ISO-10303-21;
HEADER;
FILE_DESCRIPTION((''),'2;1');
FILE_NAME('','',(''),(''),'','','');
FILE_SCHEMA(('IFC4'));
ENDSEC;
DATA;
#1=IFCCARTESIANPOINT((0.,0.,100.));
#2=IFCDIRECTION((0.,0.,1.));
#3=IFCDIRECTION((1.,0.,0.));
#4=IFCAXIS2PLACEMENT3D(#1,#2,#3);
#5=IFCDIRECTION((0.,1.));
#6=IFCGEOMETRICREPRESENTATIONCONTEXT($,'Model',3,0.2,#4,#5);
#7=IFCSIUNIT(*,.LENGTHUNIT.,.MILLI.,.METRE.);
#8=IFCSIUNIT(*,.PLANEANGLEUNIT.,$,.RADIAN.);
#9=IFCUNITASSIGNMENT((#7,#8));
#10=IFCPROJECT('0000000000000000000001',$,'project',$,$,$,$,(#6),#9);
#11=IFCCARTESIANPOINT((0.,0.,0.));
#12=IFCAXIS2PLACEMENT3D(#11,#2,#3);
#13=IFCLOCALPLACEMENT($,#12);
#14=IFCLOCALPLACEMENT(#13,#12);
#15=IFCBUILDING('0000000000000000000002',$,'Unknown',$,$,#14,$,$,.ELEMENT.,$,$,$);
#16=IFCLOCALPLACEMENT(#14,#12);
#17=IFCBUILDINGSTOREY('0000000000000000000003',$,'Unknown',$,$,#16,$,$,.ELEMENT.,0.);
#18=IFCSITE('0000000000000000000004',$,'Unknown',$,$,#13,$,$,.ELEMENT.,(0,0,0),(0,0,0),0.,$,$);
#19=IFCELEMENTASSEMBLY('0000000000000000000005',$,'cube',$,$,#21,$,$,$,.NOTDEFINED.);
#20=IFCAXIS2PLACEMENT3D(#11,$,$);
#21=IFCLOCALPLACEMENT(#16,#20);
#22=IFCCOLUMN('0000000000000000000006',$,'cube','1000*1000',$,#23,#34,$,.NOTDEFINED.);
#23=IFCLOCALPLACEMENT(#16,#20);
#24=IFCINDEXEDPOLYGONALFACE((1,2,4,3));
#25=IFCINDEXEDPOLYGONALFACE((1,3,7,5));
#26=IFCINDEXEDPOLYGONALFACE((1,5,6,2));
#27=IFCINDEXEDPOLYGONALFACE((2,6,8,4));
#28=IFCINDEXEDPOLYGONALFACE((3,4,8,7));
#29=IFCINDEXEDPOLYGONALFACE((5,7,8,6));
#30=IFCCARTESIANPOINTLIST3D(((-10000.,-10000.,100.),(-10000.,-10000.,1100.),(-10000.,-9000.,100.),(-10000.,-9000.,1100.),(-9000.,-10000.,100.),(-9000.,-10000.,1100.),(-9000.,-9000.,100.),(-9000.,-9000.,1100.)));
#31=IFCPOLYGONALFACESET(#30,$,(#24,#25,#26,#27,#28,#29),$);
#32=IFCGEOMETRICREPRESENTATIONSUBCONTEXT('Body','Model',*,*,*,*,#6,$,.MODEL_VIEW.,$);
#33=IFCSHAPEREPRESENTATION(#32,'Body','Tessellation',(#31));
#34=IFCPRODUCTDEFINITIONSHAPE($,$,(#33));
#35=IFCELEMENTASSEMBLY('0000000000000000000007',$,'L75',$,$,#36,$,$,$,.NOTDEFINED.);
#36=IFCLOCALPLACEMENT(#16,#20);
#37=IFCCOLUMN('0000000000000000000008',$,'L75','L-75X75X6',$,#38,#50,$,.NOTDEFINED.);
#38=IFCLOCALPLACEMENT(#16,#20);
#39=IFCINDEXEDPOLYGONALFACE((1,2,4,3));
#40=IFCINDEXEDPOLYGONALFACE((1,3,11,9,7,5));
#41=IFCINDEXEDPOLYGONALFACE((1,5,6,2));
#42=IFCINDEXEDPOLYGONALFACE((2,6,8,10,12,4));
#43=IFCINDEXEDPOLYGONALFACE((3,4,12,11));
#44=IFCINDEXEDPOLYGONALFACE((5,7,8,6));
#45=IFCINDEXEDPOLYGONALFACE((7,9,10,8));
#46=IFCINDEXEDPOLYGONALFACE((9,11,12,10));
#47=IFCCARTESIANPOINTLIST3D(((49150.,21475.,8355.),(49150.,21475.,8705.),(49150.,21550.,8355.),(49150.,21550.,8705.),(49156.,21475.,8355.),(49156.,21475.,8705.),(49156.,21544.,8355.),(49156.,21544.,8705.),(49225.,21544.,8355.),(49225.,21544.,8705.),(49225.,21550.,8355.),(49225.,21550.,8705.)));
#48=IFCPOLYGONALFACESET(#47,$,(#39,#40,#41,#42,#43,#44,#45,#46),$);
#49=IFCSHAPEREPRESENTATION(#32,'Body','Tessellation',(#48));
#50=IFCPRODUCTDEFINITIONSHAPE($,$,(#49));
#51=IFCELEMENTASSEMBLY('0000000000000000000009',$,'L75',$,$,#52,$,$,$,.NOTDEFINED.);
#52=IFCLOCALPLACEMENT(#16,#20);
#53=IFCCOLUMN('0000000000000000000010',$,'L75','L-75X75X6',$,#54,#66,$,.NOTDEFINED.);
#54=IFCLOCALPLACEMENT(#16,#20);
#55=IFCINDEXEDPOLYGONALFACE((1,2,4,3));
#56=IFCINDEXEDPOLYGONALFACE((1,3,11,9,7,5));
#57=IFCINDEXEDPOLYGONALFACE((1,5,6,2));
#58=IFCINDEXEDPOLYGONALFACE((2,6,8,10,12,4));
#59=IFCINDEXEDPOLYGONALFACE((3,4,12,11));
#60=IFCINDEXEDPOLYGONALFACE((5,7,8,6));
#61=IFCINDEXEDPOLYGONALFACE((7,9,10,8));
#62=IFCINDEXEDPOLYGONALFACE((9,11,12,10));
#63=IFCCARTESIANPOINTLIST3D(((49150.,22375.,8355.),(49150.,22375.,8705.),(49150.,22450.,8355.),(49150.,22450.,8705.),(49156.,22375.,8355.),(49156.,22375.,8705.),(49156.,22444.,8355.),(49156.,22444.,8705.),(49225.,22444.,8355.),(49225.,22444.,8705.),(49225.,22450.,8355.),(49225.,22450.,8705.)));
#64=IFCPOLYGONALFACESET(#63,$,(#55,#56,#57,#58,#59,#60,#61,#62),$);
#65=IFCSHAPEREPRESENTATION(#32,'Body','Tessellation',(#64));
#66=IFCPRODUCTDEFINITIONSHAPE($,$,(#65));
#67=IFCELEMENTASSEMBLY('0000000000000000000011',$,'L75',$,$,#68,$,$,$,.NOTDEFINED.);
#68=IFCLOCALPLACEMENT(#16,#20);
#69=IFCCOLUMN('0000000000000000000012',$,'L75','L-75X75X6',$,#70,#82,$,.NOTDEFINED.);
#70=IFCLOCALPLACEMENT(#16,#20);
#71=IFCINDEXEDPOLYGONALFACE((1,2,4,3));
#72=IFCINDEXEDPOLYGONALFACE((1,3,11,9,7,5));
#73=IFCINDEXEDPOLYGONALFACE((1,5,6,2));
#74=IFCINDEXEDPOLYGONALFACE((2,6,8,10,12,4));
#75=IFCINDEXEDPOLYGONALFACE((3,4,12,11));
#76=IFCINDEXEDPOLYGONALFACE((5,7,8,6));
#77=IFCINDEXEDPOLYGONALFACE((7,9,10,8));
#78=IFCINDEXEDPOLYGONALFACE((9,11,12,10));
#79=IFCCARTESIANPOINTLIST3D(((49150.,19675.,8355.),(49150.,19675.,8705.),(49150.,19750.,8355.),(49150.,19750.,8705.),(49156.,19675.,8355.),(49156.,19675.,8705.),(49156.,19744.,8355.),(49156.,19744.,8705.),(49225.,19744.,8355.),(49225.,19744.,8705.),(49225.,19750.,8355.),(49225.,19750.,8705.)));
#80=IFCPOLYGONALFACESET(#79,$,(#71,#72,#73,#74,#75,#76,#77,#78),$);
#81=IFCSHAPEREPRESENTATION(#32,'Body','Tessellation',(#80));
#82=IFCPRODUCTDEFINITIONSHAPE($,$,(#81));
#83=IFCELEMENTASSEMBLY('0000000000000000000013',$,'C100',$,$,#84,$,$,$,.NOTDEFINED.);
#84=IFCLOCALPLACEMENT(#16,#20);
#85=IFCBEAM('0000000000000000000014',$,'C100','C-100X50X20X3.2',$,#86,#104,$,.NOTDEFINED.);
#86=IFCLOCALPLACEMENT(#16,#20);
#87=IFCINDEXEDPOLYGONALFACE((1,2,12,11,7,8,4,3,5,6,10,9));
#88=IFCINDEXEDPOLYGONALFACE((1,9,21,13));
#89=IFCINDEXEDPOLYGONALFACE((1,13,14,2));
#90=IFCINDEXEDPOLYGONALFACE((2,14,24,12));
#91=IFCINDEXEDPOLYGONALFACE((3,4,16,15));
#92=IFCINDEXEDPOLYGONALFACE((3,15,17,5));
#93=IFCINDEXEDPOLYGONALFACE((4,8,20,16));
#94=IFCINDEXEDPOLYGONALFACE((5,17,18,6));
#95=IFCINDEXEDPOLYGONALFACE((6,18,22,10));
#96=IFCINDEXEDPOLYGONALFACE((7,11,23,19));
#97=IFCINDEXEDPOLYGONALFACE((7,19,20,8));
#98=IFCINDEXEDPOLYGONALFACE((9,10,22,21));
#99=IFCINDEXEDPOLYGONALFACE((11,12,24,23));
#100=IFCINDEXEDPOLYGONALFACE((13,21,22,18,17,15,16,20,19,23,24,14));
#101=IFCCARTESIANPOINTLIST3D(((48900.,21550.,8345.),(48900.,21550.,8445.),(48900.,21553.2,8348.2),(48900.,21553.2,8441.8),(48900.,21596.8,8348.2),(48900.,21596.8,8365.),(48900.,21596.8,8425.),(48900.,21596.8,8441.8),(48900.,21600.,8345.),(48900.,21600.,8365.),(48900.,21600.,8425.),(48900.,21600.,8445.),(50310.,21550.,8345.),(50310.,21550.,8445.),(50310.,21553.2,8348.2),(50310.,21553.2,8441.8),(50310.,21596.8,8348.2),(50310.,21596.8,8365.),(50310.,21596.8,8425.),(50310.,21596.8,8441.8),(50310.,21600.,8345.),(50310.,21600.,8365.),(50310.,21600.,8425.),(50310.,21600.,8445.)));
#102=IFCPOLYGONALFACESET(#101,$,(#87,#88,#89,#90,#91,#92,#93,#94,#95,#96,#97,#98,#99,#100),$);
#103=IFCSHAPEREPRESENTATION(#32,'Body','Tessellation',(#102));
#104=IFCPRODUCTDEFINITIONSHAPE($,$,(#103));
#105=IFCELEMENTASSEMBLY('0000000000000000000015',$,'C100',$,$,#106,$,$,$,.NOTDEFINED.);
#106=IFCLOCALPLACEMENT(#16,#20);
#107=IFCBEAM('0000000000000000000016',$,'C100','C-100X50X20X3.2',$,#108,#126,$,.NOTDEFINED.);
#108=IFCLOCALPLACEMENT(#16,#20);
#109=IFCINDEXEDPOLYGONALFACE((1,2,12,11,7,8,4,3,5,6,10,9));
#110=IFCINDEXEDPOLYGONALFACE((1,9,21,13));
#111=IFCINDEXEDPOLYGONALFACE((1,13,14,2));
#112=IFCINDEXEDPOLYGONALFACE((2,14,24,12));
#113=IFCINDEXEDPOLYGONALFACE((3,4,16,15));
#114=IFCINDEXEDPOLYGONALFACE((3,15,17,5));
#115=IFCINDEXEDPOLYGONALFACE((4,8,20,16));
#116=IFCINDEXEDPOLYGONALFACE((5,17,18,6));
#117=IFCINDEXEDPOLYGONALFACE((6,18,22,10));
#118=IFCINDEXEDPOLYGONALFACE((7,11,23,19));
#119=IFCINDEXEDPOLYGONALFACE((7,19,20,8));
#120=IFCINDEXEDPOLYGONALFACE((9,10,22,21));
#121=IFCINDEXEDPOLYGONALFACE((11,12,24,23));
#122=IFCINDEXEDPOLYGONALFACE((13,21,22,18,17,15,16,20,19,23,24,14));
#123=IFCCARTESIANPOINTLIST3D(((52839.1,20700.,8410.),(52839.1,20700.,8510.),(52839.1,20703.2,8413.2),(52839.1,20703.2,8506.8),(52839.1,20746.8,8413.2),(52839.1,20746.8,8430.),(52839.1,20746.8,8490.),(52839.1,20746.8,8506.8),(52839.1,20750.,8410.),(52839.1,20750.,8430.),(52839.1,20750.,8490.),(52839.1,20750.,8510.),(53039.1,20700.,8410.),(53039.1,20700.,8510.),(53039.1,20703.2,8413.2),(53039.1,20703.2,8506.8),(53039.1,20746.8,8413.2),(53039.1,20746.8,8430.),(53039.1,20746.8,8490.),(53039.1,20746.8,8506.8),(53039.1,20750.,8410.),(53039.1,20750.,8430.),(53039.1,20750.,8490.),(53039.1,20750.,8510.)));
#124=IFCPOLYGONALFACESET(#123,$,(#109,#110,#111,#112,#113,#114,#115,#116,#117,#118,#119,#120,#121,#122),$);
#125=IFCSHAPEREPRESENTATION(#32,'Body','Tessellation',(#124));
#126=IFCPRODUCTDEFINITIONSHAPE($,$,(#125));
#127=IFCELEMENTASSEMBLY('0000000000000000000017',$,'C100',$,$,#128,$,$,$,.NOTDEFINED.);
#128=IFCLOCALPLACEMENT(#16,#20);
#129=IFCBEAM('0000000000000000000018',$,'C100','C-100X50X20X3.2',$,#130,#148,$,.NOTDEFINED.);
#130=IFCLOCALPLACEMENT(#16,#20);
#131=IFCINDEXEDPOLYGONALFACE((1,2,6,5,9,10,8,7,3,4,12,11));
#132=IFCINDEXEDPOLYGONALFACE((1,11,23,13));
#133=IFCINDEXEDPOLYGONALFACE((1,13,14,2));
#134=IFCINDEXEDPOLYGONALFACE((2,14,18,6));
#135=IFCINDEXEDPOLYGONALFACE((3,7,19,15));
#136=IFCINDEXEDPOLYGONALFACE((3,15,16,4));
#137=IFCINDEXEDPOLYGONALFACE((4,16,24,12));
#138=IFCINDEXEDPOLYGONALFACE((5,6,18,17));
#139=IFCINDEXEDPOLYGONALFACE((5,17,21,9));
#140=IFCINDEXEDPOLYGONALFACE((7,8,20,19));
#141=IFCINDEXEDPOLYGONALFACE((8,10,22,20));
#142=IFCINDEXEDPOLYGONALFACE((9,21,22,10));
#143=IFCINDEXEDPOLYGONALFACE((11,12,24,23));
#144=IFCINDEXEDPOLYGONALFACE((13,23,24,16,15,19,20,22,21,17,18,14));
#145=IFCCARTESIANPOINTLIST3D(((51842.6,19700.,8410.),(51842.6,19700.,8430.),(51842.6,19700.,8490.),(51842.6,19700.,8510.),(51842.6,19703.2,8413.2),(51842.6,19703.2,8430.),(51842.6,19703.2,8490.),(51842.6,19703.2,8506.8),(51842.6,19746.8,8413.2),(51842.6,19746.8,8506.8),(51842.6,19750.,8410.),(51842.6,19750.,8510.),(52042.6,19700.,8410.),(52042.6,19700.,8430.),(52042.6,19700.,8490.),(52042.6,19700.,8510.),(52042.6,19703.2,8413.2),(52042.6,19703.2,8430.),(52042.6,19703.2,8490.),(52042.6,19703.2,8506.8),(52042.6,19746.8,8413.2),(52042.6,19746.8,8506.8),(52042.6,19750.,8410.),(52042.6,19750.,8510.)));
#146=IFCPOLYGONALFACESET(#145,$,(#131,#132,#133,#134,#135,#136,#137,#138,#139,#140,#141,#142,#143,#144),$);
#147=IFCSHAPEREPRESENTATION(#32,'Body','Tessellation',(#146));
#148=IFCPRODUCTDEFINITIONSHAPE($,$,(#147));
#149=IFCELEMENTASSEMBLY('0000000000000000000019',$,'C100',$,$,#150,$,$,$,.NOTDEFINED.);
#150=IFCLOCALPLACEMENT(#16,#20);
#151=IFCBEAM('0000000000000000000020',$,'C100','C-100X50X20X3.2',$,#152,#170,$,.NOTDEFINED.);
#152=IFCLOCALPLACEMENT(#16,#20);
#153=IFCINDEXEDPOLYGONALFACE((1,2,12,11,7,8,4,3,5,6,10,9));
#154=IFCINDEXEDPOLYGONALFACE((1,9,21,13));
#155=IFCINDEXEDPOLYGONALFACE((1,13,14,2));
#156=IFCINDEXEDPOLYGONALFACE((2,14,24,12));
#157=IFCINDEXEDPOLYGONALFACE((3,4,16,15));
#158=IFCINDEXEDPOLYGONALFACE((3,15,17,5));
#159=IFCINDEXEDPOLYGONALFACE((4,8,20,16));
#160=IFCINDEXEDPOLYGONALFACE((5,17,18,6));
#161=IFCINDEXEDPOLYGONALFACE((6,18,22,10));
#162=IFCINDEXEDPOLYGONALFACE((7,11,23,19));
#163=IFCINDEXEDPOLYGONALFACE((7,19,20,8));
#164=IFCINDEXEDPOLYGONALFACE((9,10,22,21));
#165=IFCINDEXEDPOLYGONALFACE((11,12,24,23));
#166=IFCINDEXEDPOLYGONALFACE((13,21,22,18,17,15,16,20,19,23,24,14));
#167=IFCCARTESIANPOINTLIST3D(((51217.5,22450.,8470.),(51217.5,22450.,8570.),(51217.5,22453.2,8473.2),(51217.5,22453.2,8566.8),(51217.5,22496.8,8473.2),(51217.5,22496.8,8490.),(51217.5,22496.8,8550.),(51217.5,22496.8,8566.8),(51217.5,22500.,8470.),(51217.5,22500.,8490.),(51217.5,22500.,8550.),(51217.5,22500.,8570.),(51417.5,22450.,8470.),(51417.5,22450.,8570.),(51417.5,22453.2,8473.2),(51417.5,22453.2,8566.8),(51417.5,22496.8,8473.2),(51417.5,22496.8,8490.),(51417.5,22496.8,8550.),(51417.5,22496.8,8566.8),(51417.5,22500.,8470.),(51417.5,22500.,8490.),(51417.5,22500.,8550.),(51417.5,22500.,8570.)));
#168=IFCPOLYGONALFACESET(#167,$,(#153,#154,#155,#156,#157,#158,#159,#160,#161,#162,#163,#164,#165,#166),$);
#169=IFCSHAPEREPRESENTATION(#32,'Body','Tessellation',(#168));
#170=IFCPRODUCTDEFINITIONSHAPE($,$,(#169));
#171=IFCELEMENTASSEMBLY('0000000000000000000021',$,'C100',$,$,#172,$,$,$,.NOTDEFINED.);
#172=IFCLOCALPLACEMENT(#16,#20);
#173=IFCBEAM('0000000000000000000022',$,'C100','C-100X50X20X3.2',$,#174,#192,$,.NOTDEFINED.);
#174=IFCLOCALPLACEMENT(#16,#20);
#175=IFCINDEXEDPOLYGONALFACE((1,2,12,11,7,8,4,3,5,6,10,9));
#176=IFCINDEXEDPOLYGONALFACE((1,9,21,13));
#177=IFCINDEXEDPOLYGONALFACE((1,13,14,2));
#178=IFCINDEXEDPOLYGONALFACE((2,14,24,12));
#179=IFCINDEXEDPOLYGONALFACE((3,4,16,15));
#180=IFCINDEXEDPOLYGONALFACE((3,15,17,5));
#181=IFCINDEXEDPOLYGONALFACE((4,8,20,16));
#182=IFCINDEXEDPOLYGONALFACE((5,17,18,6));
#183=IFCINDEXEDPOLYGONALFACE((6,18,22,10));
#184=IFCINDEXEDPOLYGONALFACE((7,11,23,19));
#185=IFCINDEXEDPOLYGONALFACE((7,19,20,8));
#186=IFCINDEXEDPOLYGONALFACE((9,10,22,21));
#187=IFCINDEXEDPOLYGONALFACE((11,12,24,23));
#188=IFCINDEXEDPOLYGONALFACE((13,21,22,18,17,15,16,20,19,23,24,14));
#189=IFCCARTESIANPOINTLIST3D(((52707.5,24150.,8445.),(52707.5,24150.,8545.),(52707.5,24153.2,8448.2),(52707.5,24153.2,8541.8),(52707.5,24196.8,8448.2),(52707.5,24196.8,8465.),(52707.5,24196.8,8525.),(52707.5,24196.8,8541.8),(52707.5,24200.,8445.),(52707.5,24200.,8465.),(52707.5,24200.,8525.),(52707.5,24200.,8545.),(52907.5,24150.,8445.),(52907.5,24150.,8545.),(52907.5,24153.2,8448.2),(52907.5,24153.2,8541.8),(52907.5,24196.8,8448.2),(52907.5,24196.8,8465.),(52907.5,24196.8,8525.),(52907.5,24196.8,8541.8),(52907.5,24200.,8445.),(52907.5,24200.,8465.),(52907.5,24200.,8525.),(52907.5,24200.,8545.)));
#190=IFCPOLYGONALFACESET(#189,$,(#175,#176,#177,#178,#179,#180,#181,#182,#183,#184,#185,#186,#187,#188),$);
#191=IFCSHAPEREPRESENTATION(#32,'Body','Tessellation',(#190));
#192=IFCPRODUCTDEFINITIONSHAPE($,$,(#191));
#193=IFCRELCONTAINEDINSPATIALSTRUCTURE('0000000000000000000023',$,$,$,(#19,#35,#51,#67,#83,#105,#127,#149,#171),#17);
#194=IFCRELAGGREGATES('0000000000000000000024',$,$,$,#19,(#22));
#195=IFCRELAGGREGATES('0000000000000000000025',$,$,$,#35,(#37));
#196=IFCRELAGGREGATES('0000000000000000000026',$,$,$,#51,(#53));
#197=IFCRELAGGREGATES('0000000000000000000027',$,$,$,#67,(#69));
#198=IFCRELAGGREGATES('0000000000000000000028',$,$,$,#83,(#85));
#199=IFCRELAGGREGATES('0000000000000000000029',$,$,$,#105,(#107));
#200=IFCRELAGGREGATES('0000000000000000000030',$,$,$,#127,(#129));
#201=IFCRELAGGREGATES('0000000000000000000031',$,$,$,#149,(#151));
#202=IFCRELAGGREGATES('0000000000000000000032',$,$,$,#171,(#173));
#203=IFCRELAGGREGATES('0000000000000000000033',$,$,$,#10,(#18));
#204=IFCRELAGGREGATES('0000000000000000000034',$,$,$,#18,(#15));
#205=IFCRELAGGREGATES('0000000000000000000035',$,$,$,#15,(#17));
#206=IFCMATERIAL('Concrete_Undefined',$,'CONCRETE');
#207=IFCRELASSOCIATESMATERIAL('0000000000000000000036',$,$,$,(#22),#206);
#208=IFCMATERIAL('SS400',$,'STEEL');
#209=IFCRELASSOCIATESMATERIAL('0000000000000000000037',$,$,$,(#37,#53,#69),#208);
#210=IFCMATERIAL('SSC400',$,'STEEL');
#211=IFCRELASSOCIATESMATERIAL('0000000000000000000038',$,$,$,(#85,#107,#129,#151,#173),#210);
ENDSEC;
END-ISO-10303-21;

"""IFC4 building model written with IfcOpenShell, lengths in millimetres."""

from ifc_helpers import new_model, si_unit, direction, frame, origin_with_axes, place, context, subcontext, project, spatial, line, indexed_curve, outline, extrude, material, element, aggregate, save


model = new_model("IFC4")

# Units and contexts
model_context = context("Model", 3, precision=0.2, world=frame((0.0, 0.0, 100.0), z_axis=(0.0, 0.0, 1.0), x_axis=(1.0, 0.0, 0.0)), true_north=direction((0.0, 1.0)))
body_context = subcontext(model_context, "Body", "Model", "MODEL_VIEW")
ifc_project = project(units=[si_unit("LENGTHUNIT", "METRE", prefix="MILLI"), si_unit("PLANEANGLEUNIT", "RADIAN")], contexts=[model_context])

# Site, building, storey
site_placement = place(None, origin_with_axes())
site = spatial("IfcSite", under=ifc_project, at=site_placement, Name="Unknown", CompositionType="ELEMENT", RefLatitude=(0, 0, 0), RefLongitude=(0, 0, 0), RefElevation=0.0)
building_placement = place(site_placement, origin_with_axes())
building = spatial("IfcBuilding", under=site, at=building_placement, Name="Unknown", CompositionType="ELEMENT")
storey_placement = place(building_placement, origin_with_axes())
storey = spatial("IfcBuildingStorey", under=building, at=storey_placement, Name="Unknown", CompositionType="ELEMENT", Elevation=0.0)

# Element assemblies, columns
assembly_1_placement = place(storey_placement, frame((-9500.0, -9500.0, 100.0), z_axis=(-1.0, 0.0, 0.0), x_axis=(0.0, 0.0, 1.0)))
assembly_1 = element("IfcElementAssembly", 1, at=assembly_1_placement, inside=storey, Name="cube", PredefinedType="NOTDEFINED")
ifc_material_1 = material(Name="Concrete_Undefined", Category="CONCRETE")
column_1_placement = place(assembly_1_placement, origin_with_axes())
column_1 = element("IfcColumn", 2, at=column_1_placement, material=ifc_material_1, Name="cube", Description="1000*1000", PredefinedType="NOTDEFINED", context=body_context, shape_type="SolidModel", body=[
    extrude(outline(indexed_curve([(-500.0, -500.0), (500.0, -500.0), (500.0, 500.0), (-500.0, 500.0)], segments=[line(1, 2, 3, 4, 1)])), frame((0.0, 0.0, 0.0), z_axis=(-1.0, 0.0, 0.0), x_axis=(0.0, 0.0, 1.0)), (0.0, 0.0, -1.0), 1000.0),
])
aggregate(assembly_1, [column_1])
assembly_2_placement = place(storey_placement, frame((49187.5, 21512.5, 8355.0), z_axis=(1.0, 0.0, 0.0), x_axis=(0.0, 0.0, 1.0)))
assembly_2 = element("IfcElementAssembly", 3, at=assembly_2_placement, inside=storey, Name="L75", PredefinedType="NOTDEFINED")
ifc_material_2 = material(Name="SS400", Category="STEEL")
column_2_placement = place(assembly_2_placement, origin_with_axes())
column_2 = element("IfcColumn", 4, at=column_2_placement, material=ifc_material_2, Name="L75", Description="L-75X75X6", PredefinedType="NOTDEFINED", context=body_context, shape_type="SolidModel", body=[
    extrude(outline(indexed_curve([(-37.5, -37.5), (37.5, -37.5), (37.5, -31.5), (-31.5, -31.5), (-31.5, 37.5), (-37.5, 37.5)], segments=[line(1, 2, 3, 4, 5, 6, 1)])), frame((0.0, 0.0, 0.0), z_axis=(-1.0, 0.0, 0.0), x_axis=(0.0, 0.0, 1.0)), (0.0, 0.0, -1.0), 350.0),
])
aggregate(assembly_2, [column_2])
assembly_3_placement = place(storey_placement, frame((49187.5, 22412.5, 8355.0), z_axis=(1.0, 0.0, 0.0), x_axis=(0.0, 0.0, 1.0)))
assembly_3 = element("IfcElementAssembly", 5, at=assembly_3_placement, inside=storey, Name="L75", PredefinedType="NOTDEFINED")
column_3_placement = place(assembly_3_placement, origin_with_axes())
column_3 = element("IfcColumn", 6, at=column_3_placement, material=ifc_material_2, Name="L75", Description="L-75X75X6", PredefinedType="NOTDEFINED", context=body_context, shape_type="SolidModel", body=[
    extrude(outline(indexed_curve([(-37.5, -37.5), (37.5, -37.5), (37.5, -31.5), (-31.5, -31.5), (-31.5, 37.5), (-37.5, 37.5)], segments=[line(1, 2, 3, 4, 5, 6, 1)])), frame((0.0, 0.0, 0.0), z_axis=(-1.0, 0.0, 0.0), x_axis=(0.0, 0.0, 1.0)), (0.0, 0.0, -1.0), 350.0),
])
aggregate(assembly_3, [column_3])
assembly_4_placement = place(storey_placement, frame((49187.5, 19712.5, 8355.0), z_axis=(1.0, 0.0, 0.0), x_axis=(0.0, 0.0, 1.0)))
assembly_4 = element("IfcElementAssembly", 7, at=assembly_4_placement, inside=storey, Name="L75", PredefinedType="NOTDEFINED")
column_4_placement = place(assembly_4_placement, origin_with_axes())
column_4 = element("IfcColumn", 8, at=column_4_placement, material=ifc_material_2, Name="L75", Description="L-75X75X6", PredefinedType="NOTDEFINED", context=body_context, shape_type="SolidModel", body=[
    extrude(outline(indexed_curve([(-37.5, -37.5), (37.5, -37.5), (37.5, -31.5), (-31.5, -31.5), (-31.5, 37.5), (-37.5, 37.5)], segments=[line(1, 2, 3, 4, 5, 6, 1)])), frame((0.0, 0.0, 0.0), z_axis=(-1.0, 0.0, 0.0), x_axis=(0.0, 0.0, 1.0)), (0.0, 0.0, -1.0), 350.0),
])
aggregate(assembly_4, [column_4])

# Element assemblies, beams
assembly_5_placement = place(storey_placement, frame((48900.0, 21575.0, 8395.0), z_axis=(0.0, 1.0, 0.0), x_axis=(1.0, 0.0, 0.0)))
assembly_5 = element("IfcElementAssembly", 9, at=assembly_5_placement, inside=storey, Name="C100", PredefinedType="NOTDEFINED")
ifc_material_3 = material(Name="SSC400", Category="STEEL")
beam_1_placement = place(assembly_5_placement, origin_with_axes())
beam_1 = element("IfcBeam", 10, at=beam_1_placement, material=ifc_material_3, Name="C100", Description="C-100X50X20X3.2", PredefinedType="NOTDEFINED", context=body_context, shape_type="SolidModel", body=[
    extrude(outline(indexed_curve([(25.0, -50.0), (25.0, -30.0), (21.8, -30.0), (21.8, -46.8), (-21.8, -46.8), (-21.8, 46.8), (21.8, 46.8), (21.8, 30.0), (25.0, 30.0), (25.0, 50.0), (-25.0, 50.0), (-25.0, -50.0)], segments=[line(1, 2, 3, 4, 5, 6, 7, 8, 9, 10, 11, 12, 1)])), frame((0.0, 0.0, 0.0), z_axis=(-1.0, 0.0, 0.0), x_axis=(0.0, 0.0, 1.0)), (0.0, 0.0, -1.0), 1410.0),
])
aggregate(assembly_5, [beam_1])
assembly_6_placement = place(storey_placement, frame((52839.1, 20725.0, 8460.0), z_axis=(0.0, 1.0, 0.0), x_axis=(1.0, 0.0, 0.0)))
assembly_6 = element("IfcElementAssembly", 11, at=assembly_6_placement, inside=storey, Name="C100", PredefinedType="NOTDEFINED")
beam_2_placement = place(assembly_6_placement, origin_with_axes())
beam_2 = element("IfcBeam", 12, at=beam_2_placement, material=ifc_material_3, Name="C100", Description="C-100X50X20X3.2", PredefinedType="NOTDEFINED", context=body_context, shape_type="SolidModel", body=[
    extrude(outline(indexed_curve([(25.0, -50.0), (25.0, -30.0), (21.8, -30.0), (21.8, -46.8), (-21.8, -46.8), (-21.8, 46.8), (21.8, 46.8), (21.8, 30.0), (25.0, 30.0), (25.0, 50.0), (-25.0, 50.0), (-25.0, -50.0)], segments=[line(1, 2, 3, 4, 5, 6, 7, 8, 9, 10, 11, 12, 1)])), frame((0.0, 0.0, 0.0), z_axis=(-1.0, 0.0, 0.0), x_axis=(0.0, 0.0, 1.0)), (0.0, 0.0, -1.0), 200.0),
])
aggregate(assembly_6, [beam_2])
assembly_7_placement = place(storey_placement, frame((51842.6, 19725.0, 8460.0), z_axis=(0.0, -1.0, 0.0), x_axis=(1.0, 0.0, 0.0)))
assembly_7 = element("IfcElementAssembly", 13, at=assembly_7_placement, inside=storey, Name="C100", PredefinedType="NOTDEFINED")
beam_3_placement = place(assembly_7_placement, origin_with_axes())
beam_3 = element("IfcBeam", 14, at=beam_3_placement, material=ifc_material_3, Name="C100", Description="C-100X50X20X3.2", PredefinedType="NOTDEFINED", context=body_context, shape_type="SolidModel", body=[
    extrude(outline(indexed_curve([(25.0, -50.0), (25.0, -30.0), (21.8, -30.0), (21.8, -46.8), (-21.8, -46.8), (-21.8, 46.8), (21.8, 46.8), (21.8, 30.0), (25.0, 30.0), (25.0, 50.0), (-25.0, 50.0), (-25.0, -50.0)], segments=[line(1, 2, 3, 4, 5, 6, 7, 8, 9, 10, 11, 12, 1)])), frame((0.0, 0.0, 0.0), z_axis=(-1.0, 0.0, 0.0), x_axis=(0.0, 0.0, 1.0)), (0.0, 0.0, -1.0), 200.0),
])
aggregate(assembly_7, [beam_3])
assembly_8_placement = place(storey_placement, frame((51217.5, 22475.0, 8520.0), z_axis=(0.0, 1.0, 0.0), x_axis=(1.0, 0.0, 0.0)))
assembly_8 = element("IfcElementAssembly", 15, at=assembly_8_placement, inside=storey, Name="C100", PredefinedType="NOTDEFINED")
beam_4_placement = place(assembly_8_placement, origin_with_axes())
beam_4 = element("IfcBeam", 16, at=beam_4_placement, material=ifc_material_3, Name="C100", Description="C-100X50X20X3.2", PredefinedType="NOTDEFINED", context=body_context, shape_type="SolidModel", body=[
    extrude(outline(indexed_curve([(25.0, -50.0), (25.0, -30.0), (21.8, -30.0), (21.8, -46.8), (-21.8, -46.8), (-21.8, 46.8), (21.8, 46.8), (21.8, 30.0), (25.0, 30.0), (25.0, 50.0), (-25.0, 50.0), (-25.0, -50.0)], segments=[line(1, 2, 3, 4, 5, 6, 7, 8, 9, 10, 11, 12, 1)])), frame((0.0, 0.0, 0.0), z_axis=(-1.0, 0.0, 0.0), x_axis=(0.0, 0.0, 1.0)), (0.0, 0.0, -1.0), 200.0),
])
aggregate(assembly_8, [beam_4])
assembly_9_placement = place(storey_placement, frame((52707.5, 24175.0, 8495.0), z_axis=(0.0, 1.0, 0.0), x_axis=(1.0, 0.0, 0.0)))
assembly_9 = element("IfcElementAssembly", 17, at=assembly_9_placement, inside=storey, Name="C100", PredefinedType="NOTDEFINED")
beam_5_placement = place(assembly_9_placement, origin_with_axes())
beam_5 = element("IfcBeam", 18, at=beam_5_placement, material=ifc_material_3, Name="C100", Description="C-100X50X20X3.2", PredefinedType="NOTDEFINED", context=body_context, shape_type="SolidModel", body=[
    extrude(outline(indexed_curve([(25.0, -50.0), (25.0, -30.0), (21.8, -30.0), (21.8, -46.8), (-21.8, -46.8), (-21.8, 46.8), (21.8, 46.8), (21.8, 30.0), (25.0, 30.0), (25.0, 50.0), (-25.0, 50.0), (-25.0, -50.0)], segments=[line(1, 2, 3, 4, 5, 6, 7, 8, 9, 10, 11, 12, 1)])), frame((0.0, 0.0, 0.0), z_axis=(-1.0, 0.0, 0.0), x_axis=(0.0, 0.0, 1.0)), (0.0, 0.0, -1.0), 200.0),
])
aggregate(assembly_9, [beam_5])

save(model, "model.ifc")
